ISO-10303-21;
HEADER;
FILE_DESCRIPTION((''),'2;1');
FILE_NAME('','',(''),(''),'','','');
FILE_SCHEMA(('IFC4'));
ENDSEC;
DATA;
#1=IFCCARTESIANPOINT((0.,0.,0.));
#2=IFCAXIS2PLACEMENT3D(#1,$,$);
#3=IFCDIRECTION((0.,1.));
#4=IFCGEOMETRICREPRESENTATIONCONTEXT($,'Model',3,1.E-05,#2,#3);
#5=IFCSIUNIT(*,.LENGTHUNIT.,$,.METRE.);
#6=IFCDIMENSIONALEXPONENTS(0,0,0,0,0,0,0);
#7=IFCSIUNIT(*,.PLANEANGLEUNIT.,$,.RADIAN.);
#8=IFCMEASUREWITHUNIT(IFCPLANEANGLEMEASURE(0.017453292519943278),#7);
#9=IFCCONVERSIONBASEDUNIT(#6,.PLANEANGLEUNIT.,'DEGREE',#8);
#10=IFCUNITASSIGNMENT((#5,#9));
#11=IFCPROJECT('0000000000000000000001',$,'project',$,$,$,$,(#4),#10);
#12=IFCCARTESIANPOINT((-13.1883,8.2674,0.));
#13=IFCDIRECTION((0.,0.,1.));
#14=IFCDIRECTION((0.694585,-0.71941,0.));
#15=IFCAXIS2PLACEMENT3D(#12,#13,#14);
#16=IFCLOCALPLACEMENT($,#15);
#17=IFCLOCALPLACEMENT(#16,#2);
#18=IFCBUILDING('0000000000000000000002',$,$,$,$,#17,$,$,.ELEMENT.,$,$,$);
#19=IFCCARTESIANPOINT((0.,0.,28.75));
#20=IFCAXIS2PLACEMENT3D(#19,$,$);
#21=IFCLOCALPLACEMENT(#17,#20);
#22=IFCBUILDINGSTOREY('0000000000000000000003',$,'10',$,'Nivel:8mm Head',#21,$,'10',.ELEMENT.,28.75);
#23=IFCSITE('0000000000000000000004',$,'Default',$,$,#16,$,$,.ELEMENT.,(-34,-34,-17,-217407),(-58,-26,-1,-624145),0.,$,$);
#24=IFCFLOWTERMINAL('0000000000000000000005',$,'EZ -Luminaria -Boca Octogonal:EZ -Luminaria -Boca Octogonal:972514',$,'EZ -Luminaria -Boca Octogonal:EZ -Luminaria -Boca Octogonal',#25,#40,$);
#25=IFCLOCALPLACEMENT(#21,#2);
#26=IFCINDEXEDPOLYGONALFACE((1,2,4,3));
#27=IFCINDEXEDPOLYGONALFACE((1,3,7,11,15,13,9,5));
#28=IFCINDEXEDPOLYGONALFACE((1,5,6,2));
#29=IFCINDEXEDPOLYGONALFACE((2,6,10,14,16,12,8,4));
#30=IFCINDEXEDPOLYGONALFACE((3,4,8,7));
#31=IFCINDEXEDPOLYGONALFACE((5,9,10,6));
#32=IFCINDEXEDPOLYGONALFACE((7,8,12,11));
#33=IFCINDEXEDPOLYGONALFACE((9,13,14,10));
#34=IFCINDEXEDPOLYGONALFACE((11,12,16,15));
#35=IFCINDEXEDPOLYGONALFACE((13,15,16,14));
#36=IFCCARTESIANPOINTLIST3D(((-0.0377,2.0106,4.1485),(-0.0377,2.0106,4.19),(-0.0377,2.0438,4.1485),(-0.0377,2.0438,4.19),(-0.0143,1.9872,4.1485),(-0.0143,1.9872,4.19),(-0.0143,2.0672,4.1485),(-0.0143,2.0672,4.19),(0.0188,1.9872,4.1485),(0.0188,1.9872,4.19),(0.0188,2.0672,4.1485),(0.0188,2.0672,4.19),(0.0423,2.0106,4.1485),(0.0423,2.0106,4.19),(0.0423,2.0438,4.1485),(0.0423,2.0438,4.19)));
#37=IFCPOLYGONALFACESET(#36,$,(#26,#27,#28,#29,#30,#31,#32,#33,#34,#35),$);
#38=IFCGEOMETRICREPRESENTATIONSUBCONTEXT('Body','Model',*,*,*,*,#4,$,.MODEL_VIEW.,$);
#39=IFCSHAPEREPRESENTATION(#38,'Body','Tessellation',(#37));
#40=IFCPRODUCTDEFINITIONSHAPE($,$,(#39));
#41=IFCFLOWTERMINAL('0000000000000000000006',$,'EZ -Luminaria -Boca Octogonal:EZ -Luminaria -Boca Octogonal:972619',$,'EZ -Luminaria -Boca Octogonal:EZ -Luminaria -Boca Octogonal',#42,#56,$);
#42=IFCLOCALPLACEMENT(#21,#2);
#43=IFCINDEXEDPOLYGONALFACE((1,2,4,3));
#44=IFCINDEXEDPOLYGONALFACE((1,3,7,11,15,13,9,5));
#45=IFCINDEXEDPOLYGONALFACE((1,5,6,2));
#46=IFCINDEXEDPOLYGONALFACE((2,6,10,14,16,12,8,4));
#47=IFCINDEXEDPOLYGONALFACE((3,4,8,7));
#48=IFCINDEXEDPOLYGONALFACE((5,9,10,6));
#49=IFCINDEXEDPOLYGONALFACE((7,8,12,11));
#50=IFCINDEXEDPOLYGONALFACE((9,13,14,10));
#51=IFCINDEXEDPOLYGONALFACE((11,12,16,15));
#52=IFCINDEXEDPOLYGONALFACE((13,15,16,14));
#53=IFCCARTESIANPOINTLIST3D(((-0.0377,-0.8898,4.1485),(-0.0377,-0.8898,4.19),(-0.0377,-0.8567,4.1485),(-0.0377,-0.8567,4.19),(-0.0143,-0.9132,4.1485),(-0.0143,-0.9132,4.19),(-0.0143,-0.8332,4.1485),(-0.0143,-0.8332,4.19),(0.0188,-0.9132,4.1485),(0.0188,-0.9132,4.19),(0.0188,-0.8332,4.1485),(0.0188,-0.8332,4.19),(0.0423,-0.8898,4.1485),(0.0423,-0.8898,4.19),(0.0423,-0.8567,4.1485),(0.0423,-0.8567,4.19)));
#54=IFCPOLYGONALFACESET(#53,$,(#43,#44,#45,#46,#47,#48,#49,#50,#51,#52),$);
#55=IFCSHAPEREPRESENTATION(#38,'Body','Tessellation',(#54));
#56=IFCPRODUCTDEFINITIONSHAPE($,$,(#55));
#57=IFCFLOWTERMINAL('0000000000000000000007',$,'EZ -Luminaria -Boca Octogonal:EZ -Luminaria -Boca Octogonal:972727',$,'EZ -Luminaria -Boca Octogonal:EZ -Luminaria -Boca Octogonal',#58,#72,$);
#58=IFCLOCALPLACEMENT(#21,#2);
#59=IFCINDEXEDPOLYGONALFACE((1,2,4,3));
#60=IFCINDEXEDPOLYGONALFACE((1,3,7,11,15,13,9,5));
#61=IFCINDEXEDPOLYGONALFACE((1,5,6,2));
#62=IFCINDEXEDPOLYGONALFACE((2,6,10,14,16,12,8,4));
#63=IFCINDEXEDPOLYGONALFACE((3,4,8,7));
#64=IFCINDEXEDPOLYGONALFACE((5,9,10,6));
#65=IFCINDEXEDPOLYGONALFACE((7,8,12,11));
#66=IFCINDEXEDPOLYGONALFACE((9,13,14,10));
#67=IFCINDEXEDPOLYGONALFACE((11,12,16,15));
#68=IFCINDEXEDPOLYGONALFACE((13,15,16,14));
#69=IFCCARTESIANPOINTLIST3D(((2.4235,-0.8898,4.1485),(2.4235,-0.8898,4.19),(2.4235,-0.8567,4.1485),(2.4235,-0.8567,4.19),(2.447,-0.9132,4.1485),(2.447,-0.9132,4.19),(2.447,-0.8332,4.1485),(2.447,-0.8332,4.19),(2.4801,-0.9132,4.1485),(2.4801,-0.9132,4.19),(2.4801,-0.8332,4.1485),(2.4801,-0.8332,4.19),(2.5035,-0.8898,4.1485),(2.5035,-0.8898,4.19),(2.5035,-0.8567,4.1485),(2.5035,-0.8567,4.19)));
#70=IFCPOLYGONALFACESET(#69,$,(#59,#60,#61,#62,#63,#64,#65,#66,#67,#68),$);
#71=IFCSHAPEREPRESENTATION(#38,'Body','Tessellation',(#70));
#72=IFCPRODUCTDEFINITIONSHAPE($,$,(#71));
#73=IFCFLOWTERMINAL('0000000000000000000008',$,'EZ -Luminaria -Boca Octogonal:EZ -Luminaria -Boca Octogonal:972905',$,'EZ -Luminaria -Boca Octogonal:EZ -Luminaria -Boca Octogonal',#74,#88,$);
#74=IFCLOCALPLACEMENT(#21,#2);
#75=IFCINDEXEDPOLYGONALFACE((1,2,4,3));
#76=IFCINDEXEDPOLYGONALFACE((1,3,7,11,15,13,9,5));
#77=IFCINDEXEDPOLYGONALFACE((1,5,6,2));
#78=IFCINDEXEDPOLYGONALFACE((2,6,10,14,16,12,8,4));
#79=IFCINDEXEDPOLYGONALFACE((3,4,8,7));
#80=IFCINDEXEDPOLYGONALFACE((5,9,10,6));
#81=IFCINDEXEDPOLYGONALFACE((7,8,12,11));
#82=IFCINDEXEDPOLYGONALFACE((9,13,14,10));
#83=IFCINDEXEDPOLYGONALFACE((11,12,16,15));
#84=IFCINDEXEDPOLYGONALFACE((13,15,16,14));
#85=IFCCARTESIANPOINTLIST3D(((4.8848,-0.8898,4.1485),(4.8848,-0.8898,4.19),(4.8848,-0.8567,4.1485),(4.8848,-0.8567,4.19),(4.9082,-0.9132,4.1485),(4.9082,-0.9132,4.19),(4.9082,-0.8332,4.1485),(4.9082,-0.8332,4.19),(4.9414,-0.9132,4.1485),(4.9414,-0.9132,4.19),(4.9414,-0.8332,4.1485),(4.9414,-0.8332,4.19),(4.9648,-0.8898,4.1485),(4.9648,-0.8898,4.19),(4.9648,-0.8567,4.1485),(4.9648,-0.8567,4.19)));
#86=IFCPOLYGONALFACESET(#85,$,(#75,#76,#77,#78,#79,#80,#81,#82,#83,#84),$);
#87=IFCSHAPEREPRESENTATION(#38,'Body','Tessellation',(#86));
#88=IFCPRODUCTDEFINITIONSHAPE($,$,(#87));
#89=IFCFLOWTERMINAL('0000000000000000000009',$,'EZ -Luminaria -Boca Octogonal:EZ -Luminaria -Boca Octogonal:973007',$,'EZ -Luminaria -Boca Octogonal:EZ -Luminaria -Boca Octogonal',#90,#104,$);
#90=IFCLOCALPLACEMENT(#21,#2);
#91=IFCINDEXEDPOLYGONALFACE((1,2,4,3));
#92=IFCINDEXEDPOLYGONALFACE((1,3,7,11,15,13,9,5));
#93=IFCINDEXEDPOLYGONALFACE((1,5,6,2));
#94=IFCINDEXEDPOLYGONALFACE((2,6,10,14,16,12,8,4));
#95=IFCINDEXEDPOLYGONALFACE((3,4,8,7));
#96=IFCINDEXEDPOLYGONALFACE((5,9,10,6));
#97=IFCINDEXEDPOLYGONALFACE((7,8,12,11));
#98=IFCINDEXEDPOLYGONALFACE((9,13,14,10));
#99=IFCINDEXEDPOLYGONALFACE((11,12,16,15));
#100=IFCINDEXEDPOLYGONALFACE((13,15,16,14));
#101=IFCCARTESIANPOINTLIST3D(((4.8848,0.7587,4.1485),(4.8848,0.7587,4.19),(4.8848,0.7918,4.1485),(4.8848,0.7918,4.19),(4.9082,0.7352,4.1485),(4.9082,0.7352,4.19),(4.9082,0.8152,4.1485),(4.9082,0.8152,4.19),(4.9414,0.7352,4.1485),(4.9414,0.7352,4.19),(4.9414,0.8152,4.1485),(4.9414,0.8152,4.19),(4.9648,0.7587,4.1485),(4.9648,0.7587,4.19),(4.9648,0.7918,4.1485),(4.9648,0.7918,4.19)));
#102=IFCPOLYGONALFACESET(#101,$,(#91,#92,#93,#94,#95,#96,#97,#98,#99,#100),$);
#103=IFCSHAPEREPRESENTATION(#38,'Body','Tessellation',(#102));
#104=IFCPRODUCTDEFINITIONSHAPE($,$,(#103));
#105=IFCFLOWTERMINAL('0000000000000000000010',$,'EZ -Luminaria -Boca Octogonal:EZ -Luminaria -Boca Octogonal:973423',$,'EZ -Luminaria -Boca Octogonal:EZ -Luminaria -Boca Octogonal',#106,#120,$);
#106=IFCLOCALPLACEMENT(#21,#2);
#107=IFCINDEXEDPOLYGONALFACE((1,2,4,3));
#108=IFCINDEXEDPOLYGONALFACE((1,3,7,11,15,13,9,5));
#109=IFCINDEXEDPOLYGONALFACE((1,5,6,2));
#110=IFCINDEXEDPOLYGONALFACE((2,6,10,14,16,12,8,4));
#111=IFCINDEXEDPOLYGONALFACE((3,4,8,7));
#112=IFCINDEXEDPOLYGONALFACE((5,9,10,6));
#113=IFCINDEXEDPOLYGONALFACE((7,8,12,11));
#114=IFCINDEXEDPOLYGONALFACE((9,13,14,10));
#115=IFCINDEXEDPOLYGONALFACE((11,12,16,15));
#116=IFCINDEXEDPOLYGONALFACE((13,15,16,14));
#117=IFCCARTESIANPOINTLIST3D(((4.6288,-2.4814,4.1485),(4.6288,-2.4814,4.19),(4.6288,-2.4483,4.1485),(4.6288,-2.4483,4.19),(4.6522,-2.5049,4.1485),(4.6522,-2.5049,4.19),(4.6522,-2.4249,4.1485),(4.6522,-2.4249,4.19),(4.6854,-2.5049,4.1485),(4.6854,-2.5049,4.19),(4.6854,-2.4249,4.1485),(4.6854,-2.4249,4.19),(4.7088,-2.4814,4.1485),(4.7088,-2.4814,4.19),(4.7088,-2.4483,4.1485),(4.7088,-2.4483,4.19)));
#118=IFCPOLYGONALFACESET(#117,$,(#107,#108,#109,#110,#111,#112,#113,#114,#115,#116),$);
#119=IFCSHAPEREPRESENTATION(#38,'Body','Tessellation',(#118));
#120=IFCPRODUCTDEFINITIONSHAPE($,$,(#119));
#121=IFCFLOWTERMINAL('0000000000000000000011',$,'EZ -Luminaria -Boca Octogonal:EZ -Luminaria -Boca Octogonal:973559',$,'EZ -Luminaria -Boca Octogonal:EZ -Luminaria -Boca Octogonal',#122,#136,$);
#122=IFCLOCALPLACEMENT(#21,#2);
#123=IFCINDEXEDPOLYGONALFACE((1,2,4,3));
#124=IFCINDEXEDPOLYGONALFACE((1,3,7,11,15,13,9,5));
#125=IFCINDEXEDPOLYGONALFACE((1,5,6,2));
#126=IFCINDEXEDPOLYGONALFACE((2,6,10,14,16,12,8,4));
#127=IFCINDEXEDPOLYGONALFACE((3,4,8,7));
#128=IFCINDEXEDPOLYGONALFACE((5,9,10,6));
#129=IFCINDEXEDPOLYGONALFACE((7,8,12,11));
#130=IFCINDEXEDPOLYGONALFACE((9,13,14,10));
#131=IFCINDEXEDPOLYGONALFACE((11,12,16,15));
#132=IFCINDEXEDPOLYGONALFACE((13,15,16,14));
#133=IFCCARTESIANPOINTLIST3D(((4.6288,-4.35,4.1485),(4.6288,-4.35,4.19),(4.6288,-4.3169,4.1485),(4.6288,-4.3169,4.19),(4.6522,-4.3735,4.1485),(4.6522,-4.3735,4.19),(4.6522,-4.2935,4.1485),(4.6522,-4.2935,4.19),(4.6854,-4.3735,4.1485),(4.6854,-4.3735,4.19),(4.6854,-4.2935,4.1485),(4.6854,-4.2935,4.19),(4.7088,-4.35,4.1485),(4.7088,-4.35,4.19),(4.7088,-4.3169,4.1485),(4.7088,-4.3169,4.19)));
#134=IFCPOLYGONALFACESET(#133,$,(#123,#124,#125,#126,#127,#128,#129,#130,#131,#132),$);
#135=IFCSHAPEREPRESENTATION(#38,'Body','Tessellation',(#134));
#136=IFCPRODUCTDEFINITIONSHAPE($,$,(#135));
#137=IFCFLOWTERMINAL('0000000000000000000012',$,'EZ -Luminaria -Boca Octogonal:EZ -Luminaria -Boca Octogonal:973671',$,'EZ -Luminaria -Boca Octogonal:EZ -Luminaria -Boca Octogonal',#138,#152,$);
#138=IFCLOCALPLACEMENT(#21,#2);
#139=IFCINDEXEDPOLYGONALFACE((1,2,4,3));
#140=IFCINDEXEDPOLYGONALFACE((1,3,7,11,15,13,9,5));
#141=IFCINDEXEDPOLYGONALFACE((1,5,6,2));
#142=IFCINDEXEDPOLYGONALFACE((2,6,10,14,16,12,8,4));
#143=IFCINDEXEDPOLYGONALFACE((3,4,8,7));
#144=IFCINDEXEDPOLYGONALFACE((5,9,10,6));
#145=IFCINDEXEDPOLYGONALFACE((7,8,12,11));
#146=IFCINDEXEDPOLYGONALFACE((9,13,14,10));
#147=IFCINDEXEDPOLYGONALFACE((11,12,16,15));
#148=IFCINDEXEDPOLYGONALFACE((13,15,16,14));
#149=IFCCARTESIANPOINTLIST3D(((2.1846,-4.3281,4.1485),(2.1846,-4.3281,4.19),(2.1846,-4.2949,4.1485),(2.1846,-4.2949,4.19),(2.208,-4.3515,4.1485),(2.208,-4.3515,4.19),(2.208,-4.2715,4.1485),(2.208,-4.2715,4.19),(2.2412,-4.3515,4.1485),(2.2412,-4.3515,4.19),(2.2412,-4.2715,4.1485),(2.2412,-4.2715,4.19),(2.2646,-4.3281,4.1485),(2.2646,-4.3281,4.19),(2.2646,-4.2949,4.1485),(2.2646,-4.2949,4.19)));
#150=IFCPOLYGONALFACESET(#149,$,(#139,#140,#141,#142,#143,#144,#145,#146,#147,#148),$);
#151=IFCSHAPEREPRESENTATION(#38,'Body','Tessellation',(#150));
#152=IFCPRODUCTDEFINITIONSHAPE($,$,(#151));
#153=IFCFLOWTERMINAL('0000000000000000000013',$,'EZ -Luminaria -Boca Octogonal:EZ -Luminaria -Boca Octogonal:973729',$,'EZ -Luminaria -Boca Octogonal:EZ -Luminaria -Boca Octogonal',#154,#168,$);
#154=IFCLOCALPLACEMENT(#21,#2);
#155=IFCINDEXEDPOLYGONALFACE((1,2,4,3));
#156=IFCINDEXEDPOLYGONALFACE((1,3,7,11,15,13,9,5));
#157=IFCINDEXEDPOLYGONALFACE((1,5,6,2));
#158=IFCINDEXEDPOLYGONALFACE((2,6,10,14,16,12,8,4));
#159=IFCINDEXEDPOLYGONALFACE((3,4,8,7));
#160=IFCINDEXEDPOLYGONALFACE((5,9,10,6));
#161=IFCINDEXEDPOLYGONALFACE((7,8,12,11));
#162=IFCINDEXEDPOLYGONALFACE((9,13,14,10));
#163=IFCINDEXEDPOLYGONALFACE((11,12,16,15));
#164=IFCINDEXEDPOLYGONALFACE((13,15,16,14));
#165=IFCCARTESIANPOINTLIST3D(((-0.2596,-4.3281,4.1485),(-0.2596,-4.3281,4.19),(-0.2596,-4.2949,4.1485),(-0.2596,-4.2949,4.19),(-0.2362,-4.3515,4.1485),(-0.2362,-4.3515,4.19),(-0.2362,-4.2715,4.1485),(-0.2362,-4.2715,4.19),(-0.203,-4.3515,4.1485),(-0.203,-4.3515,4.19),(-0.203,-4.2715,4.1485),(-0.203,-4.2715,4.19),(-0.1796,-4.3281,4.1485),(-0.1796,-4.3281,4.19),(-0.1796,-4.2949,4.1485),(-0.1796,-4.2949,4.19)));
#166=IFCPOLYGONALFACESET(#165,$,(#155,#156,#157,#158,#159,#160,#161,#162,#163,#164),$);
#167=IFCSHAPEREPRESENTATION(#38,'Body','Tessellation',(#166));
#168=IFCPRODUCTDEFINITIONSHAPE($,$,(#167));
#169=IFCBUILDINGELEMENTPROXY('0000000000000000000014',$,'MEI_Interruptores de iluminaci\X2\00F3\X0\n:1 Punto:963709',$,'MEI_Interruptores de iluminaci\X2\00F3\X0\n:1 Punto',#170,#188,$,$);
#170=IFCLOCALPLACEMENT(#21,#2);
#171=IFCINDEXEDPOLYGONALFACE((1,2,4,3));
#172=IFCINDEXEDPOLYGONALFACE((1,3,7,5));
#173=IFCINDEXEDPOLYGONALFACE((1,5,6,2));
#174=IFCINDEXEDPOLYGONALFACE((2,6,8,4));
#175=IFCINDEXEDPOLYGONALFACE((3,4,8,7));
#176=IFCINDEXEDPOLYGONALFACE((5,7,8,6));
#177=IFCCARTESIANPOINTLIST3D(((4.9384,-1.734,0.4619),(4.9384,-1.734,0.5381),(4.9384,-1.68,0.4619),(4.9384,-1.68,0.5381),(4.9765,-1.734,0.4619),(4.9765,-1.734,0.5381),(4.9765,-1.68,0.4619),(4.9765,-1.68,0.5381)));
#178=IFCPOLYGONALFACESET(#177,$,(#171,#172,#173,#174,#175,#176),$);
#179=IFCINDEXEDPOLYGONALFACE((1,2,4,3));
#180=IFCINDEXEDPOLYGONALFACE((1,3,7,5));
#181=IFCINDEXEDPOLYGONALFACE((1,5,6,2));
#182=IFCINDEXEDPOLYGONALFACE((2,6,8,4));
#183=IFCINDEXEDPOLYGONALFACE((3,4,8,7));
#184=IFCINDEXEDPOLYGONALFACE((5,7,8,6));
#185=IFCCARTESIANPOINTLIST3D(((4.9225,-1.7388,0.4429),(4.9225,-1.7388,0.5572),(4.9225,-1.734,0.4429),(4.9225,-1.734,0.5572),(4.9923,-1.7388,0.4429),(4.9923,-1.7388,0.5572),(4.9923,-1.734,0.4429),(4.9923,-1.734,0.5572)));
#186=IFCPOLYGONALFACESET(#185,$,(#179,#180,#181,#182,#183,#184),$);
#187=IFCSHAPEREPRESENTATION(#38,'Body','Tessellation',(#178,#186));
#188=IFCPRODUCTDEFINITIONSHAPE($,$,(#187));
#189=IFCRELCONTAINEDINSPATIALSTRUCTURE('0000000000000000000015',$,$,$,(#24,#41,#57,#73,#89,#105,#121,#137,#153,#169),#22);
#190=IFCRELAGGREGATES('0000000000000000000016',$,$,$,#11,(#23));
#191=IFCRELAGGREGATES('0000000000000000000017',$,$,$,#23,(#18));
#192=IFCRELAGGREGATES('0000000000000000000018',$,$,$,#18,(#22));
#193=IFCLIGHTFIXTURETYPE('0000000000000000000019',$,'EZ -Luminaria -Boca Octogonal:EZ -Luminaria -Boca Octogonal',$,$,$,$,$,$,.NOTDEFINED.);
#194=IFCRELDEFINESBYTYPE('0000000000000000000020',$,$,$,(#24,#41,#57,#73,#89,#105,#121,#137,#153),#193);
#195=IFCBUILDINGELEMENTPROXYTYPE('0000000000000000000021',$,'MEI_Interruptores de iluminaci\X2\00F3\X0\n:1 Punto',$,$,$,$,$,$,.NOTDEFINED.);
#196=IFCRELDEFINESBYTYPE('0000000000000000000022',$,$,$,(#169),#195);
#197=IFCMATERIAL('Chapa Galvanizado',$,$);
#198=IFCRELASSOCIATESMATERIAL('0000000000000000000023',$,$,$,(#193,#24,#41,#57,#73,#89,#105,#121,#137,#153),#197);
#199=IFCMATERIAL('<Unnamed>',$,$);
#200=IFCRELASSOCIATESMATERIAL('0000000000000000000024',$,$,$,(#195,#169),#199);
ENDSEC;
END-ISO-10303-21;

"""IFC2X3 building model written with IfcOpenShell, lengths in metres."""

from ifc_helpers import new_model, entity, si_unit, converted_unit, direction, frame, frame_2d, origin, origin_2d_with_axis, place, context, subcontext, project, spatial, polyline, rectangle, outline, extrude, source, transform, mapped, material, type_object, type_shapes, element, save


model = new_model("IFC2X3")

# Units and contexts
model_context = context("Model", 3, precision=1e-05, world=origin(), true_north=direction((0.0, 1.0)))
body_context = subcontext(model_context, "Body", "Model", "MODEL_VIEW")
ifc_project = project(units=[si_unit("LENGTHUNIT", "METRE"), converted_unit("PLANEANGLEUNIT", "DEGREE", entity("IfcPlaneAngleMeasure", 0.017453292519943278), si_unit("PLANEANGLEUNIT", "RADIAN"), dimensions=[0, 0, 0, 0, 0, 0, 0])], contexts=[model_context])

# Site, building, storey
site_placement = place(None, frame((-13.1883, 8.2674, 0.0), z_axis=(0.0, 0.0, 1.0), x_axis=(0.694585, -0.71941, 0.0)))
site = spatial("IfcSite", under=ifc_project, at=site_placement, Name="Default", CompositionType="ELEMENT", RefLatitude=(-34, -34, -17, -217407), RefLongitude=(-58, -26, -1, -624145), RefElevation=0.0)
building_placement = place(site_placement, origin())
building = spatial("IfcBuilding", under=site, at=building_placement, CompositionType="ELEMENT")
storey_placement = place(building_placement, frame((0.0, 0.0, 28.75)))
storey = spatial("IfcBuildingStorey", under=building, at=storey_placement, Name="10", ObjectType="Nivel:8mm Head", LongName="10", CompositionType="ELEMENT", Elevation=28.75)

# Flow terminals
ifc_material_1 = material(Name="Chapa Galvanizado")
light_fixture_type = type_object("IfcLightFixtureType", Name="EZ -Luminaria -Boca Octogonal:EZ -Luminaria -Boca Octogonal", PredefinedType="NOTDEFINED", material=ifc_material_1)
shared_shape_1 = source(origin(), body_context, "Body", "SweptSolid", [
    extrude(outline(polyline([(-0.0166, -0.04), (0.0166, -0.04), (0.04, -0.0166), (0.04, 0.0166), (0.0166, 0.04), (-0.0166, 0.04), (-0.04, 0.0166), (-0.04, -0.0166), (-0.0166, -0.04)])), frame((0.0, 0.0, -0.0415), z_axis=(0.0, 0.0, 1.0), x_axis=(0.0, -1.0, 0.0)), (0.0, 0.0, 1.0), 0.0415),
])
type_shapes(light_fixture_type, [shared_shape_1])
for number, where, name in (
    (1, (0.0023, 2.0272, 4.19), "EZ -Luminaria -Boca Octogonal:EZ -Luminaria -Boca Octogonal:972514"),
    (2, (0.0023, -0.8732, 4.19), "EZ -Luminaria -Boca Octogonal:EZ -Luminaria -Boca Octogonal:972619"),
    (3, (2.4635, -0.8732, 4.19), "EZ -Luminaria -Boca Octogonal:EZ -Luminaria -Boca Octogonal:972727"),
    (4, (4.9248, -0.8732, 4.19), "EZ -Luminaria -Boca Octogonal:EZ -Luminaria -Boca Octogonal:972905"),
    (5, (4.9248, 0.7752, 4.19), "EZ -Luminaria -Boca Octogonal:EZ -Luminaria -Boca Octogonal:973007"),
    (6, (4.6688, -2.4649, 4.19), "EZ -Luminaria -Boca Octogonal:EZ -Luminaria -Boca Octogonal:973423"),
    (7, (4.6688, -4.3335, 4.19), "EZ -Luminaria -Boca Octogonal:EZ -Luminaria -Boca Octogonal:973559"),
    (8, (2.2246, -4.3115, 4.19), "EZ -Luminaria -Boca Octogonal:EZ -Luminaria -Boca Octogonal:973671"),
    (9, (-0.2196, -4.3115, 4.19), "EZ -Luminaria -Boca Octogonal:EZ -Luminaria -Boca Octogonal:973729"),
):
    element("IfcFlowTerminal", number, at=place(storey_placement, frame(where)), inside=storey, type_object=light_fixture_type, material=ifc_material_1, Name=name, ObjectType="EZ -Luminaria -Boca Octogonal:EZ -Luminaria -Boca Octogonal", context=body_context, shape_type="MappedRepresentation", body=[
        mapped(shared_shape_1, transform((0.0, 0.0, 0.0), scale=1.0)),
    ])

# Building element proxy
ifc_material_2 = material(Name="<Unnamed>")
building_element_proxy_type_1 = type_object("IfcBuildingElementProxyType", Name="MEI_Interruptores de iluminación:1 Punto", PredefinedType="NOTDEFINED", material=ifc_material_2)
shared_shape_2 = source(origin(), body_context, "Body", "SweptSolid", [
    extrude(rectangle(XDim=0.0381, YDim=0.0762, at=origin_2d_with_axis()), frame((0.0, 0.0, -0.054), z_axis=(0.0, 0.0, 1.0), x_axis=(-1.0, 0.0, 0.0)), (0.0, 0.0, 1.0), 0.054),
    extrude(rectangle(XDim=0.0698, YDim=0.1143, at=frame_2d((0.0, 0.0), x_axis=(1.0, 0.0))), frame((0.0, 0.0, 0.0), z_axis=(0.0, 0.0, 1.0), x_axis=(-1.0, 0.0, 0.0)), (0.0, 0.0, 1.0), 0.0048),
])
type_shapes(building_element_proxy_type_1, [shared_shape_2])
proxy_1_placement = place(storey_placement, frame((4.9574, -1.734, 0.5), z_axis=(0.0, -1.0, 0.0), x_axis=(1.0, 0.0, 0.0)))
element("IfcBuildingElementProxy", 10, at=proxy_1_placement, inside=storey, type_object=building_element_proxy_type_1, material=ifc_material_2, Name="MEI_Interruptores de iluminación:1 Punto:963709", ObjectType="MEI_Interruptores de iluminación:1 Punto", context=body_context, shape_type="MappedRepresentation", body=[
    mapped(shared_shape_2, transform((0.0, 0.0, 0.0), scale=1.0)),
])

save(model, "model.ifc")
